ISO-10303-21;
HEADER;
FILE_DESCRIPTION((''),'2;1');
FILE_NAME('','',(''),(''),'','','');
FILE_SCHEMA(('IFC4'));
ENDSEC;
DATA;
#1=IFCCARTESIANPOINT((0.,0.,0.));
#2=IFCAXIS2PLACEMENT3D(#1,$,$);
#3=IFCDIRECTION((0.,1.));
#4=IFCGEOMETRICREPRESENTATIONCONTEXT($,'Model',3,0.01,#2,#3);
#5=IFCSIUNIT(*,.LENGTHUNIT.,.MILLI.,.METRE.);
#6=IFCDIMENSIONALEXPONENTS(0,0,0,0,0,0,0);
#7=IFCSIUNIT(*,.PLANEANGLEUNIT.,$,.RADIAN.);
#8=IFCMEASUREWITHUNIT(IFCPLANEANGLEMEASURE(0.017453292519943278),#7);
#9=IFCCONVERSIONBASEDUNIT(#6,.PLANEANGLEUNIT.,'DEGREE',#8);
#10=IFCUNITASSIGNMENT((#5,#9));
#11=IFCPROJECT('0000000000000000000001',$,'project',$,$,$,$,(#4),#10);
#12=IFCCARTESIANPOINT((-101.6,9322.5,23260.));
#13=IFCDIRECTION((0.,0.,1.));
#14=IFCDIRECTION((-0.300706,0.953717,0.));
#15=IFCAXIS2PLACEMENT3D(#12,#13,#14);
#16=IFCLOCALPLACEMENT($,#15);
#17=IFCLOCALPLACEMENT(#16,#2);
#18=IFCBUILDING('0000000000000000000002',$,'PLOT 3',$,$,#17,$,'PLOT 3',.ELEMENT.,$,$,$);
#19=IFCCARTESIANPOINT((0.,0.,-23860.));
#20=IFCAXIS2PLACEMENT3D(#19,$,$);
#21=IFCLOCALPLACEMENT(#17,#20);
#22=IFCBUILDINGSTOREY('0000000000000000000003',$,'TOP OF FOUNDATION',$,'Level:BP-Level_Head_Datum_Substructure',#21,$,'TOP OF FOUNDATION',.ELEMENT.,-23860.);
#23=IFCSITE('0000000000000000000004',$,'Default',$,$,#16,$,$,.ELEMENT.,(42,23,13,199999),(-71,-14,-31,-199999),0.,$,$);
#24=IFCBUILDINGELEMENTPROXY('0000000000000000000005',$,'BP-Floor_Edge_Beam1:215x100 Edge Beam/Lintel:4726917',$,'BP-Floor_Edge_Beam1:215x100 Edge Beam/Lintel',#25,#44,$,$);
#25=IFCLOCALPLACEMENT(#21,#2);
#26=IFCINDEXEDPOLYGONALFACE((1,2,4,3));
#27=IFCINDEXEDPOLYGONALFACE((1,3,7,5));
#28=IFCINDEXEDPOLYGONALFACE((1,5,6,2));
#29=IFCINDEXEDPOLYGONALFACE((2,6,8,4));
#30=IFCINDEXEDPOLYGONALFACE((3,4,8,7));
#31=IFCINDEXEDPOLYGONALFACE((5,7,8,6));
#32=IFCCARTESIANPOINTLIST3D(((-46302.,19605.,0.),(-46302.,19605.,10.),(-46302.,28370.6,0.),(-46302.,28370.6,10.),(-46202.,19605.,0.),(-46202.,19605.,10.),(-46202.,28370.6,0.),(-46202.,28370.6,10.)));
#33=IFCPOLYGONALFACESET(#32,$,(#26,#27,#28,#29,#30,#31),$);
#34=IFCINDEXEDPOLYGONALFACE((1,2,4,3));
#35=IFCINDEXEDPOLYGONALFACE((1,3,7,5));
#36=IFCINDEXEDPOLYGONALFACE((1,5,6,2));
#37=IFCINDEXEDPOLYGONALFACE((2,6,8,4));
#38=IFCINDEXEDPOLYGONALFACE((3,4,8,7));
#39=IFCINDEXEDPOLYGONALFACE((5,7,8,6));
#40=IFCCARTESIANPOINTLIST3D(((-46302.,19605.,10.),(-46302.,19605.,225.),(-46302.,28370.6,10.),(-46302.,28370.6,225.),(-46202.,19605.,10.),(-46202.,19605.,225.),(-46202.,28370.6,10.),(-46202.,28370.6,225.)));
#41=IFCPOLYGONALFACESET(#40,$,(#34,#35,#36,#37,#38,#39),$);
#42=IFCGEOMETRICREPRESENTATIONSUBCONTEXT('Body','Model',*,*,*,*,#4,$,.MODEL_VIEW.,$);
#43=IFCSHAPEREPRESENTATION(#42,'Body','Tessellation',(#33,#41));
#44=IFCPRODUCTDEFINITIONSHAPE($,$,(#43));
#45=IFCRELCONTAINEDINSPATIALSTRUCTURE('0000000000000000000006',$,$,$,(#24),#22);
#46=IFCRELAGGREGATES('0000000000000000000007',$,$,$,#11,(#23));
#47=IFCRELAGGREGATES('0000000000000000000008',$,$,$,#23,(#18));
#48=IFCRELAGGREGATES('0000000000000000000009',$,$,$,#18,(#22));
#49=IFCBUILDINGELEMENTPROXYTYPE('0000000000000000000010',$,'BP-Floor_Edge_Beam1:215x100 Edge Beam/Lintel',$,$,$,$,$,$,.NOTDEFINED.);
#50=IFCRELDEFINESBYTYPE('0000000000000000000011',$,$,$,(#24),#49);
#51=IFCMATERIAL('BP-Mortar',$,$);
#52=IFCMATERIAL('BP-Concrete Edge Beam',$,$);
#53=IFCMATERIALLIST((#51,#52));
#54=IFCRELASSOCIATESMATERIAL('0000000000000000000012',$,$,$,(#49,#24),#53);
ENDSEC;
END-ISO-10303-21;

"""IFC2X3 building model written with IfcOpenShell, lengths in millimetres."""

from ifc_helpers import new_model, entity, si_unit, converted_unit, direction, frame, origin, origin_2d_with_axis, place, context, subcontext, project, spatial, rectangle, extrude, source, transform, mapped, material, material_list, type_object, type_shapes, element, save


model = new_model("IFC2X3")

# Units and contexts
model_context = context("Model", 3, precision=0.01, world=origin(), true_north=direction((0.0, 1.0)))
body_context = subcontext(model_context, "Body", "Model", "MODEL_VIEW")
ifc_project = project(units=[si_unit("LENGTHUNIT", "METRE", prefix="MILLI"), converted_unit("PLANEANGLEUNIT", "DEGREE", entity("IfcPlaneAngleMeasure", 0.017453292519943278), si_unit("PLANEANGLEUNIT", "RADIAN"), dimensions=[0, 0, 0, 0, 0, 0, 0])], contexts=[model_context])

# Site, building, storey
site_placement = place(None, frame((-101.6, 9322.5, 23260.0), z_axis=(0.0, 0.0, 1.0), x_axis=(-0.300706, 0.953717, 0.0)))
site = spatial("IfcSite", under=ifc_project, at=site_placement, Name="Default", CompositionType="ELEMENT", RefLatitude=(42, 23, 13, 199999), RefLongitude=(-71, -14, -31, -199999), RefElevation=0.0)
building_placement = place(site_placement, origin())
building = spatial("IfcBuilding", under=site, at=building_placement, Name="PLOT 3", LongName="PLOT 3", CompositionType="ELEMENT")
storey_placement = place(building_placement, frame((0.0, 0.0, -23860.0)))
storey = spatial("IfcBuildingStorey", under=building, at=storey_placement, Name="TOP OF FOUNDATION", ObjectType="Level:BP-Level_Head_Datum_Substructure", LongName="TOP OF FOUNDATION", CompositionType="ELEMENT", Elevation=-23860.0)

# Building element proxy
ifc_material_1 = material(Name="BP-Mortar")
ifc_material_2 = material(Name="BP-Concrete Edge Beam")
ifc_material_list = material_list([ifc_material_1, ifc_material_2])
building_element_proxy_type_1 = type_object("IfcBuildingElementProxyType", Name="BP-Floor_Edge_Beam1:215x100 Edge Beam/Lintel", PredefinedType="NOTDEFINED", material=ifc_material_list)
shared_shape_1 = source(origin(), body_context, "Body", "SweptSolid", [
    extrude(rectangle(XDim=100.0, YDim=8765.6, at=origin_2d_with_axis()), frame((0.0, 0.0, 0.0), z_axis=(0.0, 0.0, 1.0), x_axis=(0.0, 1.0, 0.0)), (0.0, 0.0, 1.0), 10.0),
    extrude(rectangle(XDim=100.0, YDim=8765.6, at=origin_2d_with_axis()), frame((0.0, 0.0, 10.0), z_axis=(0.0, 0.0, 1.0), x_axis=(0.0, 1.0, 0.0)), (0.0, 0.0, 1.0), 215.0),
])
type_shapes(building_element_proxy_type_1, [shared_shape_1])
proxy_1_placement = place(storey_placement, frame((-46252.0, 23987.8, 0.0), z_axis=(0.0, 0.0, 1.0), x_axis=(0.0, 1.0, 0.0)))
element("IfcBuildingElementProxy", 1, at=proxy_1_placement, inside=storey, type_object=building_element_proxy_type_1, material=ifc_material_list, Name="BP-Floor_Edge_Beam1:215x100 Edge Beam/Lintel:4726917", ObjectType="BP-Floor_Edge_Beam1:215x100 Edge Beam/Lintel", context=body_context, shape_type="MappedRepresentation", body=[
    mapped(shared_shape_1, transform((0.0, 0.0, 0.0), scale=1.0)),
])

save(model, "model.ifc")
